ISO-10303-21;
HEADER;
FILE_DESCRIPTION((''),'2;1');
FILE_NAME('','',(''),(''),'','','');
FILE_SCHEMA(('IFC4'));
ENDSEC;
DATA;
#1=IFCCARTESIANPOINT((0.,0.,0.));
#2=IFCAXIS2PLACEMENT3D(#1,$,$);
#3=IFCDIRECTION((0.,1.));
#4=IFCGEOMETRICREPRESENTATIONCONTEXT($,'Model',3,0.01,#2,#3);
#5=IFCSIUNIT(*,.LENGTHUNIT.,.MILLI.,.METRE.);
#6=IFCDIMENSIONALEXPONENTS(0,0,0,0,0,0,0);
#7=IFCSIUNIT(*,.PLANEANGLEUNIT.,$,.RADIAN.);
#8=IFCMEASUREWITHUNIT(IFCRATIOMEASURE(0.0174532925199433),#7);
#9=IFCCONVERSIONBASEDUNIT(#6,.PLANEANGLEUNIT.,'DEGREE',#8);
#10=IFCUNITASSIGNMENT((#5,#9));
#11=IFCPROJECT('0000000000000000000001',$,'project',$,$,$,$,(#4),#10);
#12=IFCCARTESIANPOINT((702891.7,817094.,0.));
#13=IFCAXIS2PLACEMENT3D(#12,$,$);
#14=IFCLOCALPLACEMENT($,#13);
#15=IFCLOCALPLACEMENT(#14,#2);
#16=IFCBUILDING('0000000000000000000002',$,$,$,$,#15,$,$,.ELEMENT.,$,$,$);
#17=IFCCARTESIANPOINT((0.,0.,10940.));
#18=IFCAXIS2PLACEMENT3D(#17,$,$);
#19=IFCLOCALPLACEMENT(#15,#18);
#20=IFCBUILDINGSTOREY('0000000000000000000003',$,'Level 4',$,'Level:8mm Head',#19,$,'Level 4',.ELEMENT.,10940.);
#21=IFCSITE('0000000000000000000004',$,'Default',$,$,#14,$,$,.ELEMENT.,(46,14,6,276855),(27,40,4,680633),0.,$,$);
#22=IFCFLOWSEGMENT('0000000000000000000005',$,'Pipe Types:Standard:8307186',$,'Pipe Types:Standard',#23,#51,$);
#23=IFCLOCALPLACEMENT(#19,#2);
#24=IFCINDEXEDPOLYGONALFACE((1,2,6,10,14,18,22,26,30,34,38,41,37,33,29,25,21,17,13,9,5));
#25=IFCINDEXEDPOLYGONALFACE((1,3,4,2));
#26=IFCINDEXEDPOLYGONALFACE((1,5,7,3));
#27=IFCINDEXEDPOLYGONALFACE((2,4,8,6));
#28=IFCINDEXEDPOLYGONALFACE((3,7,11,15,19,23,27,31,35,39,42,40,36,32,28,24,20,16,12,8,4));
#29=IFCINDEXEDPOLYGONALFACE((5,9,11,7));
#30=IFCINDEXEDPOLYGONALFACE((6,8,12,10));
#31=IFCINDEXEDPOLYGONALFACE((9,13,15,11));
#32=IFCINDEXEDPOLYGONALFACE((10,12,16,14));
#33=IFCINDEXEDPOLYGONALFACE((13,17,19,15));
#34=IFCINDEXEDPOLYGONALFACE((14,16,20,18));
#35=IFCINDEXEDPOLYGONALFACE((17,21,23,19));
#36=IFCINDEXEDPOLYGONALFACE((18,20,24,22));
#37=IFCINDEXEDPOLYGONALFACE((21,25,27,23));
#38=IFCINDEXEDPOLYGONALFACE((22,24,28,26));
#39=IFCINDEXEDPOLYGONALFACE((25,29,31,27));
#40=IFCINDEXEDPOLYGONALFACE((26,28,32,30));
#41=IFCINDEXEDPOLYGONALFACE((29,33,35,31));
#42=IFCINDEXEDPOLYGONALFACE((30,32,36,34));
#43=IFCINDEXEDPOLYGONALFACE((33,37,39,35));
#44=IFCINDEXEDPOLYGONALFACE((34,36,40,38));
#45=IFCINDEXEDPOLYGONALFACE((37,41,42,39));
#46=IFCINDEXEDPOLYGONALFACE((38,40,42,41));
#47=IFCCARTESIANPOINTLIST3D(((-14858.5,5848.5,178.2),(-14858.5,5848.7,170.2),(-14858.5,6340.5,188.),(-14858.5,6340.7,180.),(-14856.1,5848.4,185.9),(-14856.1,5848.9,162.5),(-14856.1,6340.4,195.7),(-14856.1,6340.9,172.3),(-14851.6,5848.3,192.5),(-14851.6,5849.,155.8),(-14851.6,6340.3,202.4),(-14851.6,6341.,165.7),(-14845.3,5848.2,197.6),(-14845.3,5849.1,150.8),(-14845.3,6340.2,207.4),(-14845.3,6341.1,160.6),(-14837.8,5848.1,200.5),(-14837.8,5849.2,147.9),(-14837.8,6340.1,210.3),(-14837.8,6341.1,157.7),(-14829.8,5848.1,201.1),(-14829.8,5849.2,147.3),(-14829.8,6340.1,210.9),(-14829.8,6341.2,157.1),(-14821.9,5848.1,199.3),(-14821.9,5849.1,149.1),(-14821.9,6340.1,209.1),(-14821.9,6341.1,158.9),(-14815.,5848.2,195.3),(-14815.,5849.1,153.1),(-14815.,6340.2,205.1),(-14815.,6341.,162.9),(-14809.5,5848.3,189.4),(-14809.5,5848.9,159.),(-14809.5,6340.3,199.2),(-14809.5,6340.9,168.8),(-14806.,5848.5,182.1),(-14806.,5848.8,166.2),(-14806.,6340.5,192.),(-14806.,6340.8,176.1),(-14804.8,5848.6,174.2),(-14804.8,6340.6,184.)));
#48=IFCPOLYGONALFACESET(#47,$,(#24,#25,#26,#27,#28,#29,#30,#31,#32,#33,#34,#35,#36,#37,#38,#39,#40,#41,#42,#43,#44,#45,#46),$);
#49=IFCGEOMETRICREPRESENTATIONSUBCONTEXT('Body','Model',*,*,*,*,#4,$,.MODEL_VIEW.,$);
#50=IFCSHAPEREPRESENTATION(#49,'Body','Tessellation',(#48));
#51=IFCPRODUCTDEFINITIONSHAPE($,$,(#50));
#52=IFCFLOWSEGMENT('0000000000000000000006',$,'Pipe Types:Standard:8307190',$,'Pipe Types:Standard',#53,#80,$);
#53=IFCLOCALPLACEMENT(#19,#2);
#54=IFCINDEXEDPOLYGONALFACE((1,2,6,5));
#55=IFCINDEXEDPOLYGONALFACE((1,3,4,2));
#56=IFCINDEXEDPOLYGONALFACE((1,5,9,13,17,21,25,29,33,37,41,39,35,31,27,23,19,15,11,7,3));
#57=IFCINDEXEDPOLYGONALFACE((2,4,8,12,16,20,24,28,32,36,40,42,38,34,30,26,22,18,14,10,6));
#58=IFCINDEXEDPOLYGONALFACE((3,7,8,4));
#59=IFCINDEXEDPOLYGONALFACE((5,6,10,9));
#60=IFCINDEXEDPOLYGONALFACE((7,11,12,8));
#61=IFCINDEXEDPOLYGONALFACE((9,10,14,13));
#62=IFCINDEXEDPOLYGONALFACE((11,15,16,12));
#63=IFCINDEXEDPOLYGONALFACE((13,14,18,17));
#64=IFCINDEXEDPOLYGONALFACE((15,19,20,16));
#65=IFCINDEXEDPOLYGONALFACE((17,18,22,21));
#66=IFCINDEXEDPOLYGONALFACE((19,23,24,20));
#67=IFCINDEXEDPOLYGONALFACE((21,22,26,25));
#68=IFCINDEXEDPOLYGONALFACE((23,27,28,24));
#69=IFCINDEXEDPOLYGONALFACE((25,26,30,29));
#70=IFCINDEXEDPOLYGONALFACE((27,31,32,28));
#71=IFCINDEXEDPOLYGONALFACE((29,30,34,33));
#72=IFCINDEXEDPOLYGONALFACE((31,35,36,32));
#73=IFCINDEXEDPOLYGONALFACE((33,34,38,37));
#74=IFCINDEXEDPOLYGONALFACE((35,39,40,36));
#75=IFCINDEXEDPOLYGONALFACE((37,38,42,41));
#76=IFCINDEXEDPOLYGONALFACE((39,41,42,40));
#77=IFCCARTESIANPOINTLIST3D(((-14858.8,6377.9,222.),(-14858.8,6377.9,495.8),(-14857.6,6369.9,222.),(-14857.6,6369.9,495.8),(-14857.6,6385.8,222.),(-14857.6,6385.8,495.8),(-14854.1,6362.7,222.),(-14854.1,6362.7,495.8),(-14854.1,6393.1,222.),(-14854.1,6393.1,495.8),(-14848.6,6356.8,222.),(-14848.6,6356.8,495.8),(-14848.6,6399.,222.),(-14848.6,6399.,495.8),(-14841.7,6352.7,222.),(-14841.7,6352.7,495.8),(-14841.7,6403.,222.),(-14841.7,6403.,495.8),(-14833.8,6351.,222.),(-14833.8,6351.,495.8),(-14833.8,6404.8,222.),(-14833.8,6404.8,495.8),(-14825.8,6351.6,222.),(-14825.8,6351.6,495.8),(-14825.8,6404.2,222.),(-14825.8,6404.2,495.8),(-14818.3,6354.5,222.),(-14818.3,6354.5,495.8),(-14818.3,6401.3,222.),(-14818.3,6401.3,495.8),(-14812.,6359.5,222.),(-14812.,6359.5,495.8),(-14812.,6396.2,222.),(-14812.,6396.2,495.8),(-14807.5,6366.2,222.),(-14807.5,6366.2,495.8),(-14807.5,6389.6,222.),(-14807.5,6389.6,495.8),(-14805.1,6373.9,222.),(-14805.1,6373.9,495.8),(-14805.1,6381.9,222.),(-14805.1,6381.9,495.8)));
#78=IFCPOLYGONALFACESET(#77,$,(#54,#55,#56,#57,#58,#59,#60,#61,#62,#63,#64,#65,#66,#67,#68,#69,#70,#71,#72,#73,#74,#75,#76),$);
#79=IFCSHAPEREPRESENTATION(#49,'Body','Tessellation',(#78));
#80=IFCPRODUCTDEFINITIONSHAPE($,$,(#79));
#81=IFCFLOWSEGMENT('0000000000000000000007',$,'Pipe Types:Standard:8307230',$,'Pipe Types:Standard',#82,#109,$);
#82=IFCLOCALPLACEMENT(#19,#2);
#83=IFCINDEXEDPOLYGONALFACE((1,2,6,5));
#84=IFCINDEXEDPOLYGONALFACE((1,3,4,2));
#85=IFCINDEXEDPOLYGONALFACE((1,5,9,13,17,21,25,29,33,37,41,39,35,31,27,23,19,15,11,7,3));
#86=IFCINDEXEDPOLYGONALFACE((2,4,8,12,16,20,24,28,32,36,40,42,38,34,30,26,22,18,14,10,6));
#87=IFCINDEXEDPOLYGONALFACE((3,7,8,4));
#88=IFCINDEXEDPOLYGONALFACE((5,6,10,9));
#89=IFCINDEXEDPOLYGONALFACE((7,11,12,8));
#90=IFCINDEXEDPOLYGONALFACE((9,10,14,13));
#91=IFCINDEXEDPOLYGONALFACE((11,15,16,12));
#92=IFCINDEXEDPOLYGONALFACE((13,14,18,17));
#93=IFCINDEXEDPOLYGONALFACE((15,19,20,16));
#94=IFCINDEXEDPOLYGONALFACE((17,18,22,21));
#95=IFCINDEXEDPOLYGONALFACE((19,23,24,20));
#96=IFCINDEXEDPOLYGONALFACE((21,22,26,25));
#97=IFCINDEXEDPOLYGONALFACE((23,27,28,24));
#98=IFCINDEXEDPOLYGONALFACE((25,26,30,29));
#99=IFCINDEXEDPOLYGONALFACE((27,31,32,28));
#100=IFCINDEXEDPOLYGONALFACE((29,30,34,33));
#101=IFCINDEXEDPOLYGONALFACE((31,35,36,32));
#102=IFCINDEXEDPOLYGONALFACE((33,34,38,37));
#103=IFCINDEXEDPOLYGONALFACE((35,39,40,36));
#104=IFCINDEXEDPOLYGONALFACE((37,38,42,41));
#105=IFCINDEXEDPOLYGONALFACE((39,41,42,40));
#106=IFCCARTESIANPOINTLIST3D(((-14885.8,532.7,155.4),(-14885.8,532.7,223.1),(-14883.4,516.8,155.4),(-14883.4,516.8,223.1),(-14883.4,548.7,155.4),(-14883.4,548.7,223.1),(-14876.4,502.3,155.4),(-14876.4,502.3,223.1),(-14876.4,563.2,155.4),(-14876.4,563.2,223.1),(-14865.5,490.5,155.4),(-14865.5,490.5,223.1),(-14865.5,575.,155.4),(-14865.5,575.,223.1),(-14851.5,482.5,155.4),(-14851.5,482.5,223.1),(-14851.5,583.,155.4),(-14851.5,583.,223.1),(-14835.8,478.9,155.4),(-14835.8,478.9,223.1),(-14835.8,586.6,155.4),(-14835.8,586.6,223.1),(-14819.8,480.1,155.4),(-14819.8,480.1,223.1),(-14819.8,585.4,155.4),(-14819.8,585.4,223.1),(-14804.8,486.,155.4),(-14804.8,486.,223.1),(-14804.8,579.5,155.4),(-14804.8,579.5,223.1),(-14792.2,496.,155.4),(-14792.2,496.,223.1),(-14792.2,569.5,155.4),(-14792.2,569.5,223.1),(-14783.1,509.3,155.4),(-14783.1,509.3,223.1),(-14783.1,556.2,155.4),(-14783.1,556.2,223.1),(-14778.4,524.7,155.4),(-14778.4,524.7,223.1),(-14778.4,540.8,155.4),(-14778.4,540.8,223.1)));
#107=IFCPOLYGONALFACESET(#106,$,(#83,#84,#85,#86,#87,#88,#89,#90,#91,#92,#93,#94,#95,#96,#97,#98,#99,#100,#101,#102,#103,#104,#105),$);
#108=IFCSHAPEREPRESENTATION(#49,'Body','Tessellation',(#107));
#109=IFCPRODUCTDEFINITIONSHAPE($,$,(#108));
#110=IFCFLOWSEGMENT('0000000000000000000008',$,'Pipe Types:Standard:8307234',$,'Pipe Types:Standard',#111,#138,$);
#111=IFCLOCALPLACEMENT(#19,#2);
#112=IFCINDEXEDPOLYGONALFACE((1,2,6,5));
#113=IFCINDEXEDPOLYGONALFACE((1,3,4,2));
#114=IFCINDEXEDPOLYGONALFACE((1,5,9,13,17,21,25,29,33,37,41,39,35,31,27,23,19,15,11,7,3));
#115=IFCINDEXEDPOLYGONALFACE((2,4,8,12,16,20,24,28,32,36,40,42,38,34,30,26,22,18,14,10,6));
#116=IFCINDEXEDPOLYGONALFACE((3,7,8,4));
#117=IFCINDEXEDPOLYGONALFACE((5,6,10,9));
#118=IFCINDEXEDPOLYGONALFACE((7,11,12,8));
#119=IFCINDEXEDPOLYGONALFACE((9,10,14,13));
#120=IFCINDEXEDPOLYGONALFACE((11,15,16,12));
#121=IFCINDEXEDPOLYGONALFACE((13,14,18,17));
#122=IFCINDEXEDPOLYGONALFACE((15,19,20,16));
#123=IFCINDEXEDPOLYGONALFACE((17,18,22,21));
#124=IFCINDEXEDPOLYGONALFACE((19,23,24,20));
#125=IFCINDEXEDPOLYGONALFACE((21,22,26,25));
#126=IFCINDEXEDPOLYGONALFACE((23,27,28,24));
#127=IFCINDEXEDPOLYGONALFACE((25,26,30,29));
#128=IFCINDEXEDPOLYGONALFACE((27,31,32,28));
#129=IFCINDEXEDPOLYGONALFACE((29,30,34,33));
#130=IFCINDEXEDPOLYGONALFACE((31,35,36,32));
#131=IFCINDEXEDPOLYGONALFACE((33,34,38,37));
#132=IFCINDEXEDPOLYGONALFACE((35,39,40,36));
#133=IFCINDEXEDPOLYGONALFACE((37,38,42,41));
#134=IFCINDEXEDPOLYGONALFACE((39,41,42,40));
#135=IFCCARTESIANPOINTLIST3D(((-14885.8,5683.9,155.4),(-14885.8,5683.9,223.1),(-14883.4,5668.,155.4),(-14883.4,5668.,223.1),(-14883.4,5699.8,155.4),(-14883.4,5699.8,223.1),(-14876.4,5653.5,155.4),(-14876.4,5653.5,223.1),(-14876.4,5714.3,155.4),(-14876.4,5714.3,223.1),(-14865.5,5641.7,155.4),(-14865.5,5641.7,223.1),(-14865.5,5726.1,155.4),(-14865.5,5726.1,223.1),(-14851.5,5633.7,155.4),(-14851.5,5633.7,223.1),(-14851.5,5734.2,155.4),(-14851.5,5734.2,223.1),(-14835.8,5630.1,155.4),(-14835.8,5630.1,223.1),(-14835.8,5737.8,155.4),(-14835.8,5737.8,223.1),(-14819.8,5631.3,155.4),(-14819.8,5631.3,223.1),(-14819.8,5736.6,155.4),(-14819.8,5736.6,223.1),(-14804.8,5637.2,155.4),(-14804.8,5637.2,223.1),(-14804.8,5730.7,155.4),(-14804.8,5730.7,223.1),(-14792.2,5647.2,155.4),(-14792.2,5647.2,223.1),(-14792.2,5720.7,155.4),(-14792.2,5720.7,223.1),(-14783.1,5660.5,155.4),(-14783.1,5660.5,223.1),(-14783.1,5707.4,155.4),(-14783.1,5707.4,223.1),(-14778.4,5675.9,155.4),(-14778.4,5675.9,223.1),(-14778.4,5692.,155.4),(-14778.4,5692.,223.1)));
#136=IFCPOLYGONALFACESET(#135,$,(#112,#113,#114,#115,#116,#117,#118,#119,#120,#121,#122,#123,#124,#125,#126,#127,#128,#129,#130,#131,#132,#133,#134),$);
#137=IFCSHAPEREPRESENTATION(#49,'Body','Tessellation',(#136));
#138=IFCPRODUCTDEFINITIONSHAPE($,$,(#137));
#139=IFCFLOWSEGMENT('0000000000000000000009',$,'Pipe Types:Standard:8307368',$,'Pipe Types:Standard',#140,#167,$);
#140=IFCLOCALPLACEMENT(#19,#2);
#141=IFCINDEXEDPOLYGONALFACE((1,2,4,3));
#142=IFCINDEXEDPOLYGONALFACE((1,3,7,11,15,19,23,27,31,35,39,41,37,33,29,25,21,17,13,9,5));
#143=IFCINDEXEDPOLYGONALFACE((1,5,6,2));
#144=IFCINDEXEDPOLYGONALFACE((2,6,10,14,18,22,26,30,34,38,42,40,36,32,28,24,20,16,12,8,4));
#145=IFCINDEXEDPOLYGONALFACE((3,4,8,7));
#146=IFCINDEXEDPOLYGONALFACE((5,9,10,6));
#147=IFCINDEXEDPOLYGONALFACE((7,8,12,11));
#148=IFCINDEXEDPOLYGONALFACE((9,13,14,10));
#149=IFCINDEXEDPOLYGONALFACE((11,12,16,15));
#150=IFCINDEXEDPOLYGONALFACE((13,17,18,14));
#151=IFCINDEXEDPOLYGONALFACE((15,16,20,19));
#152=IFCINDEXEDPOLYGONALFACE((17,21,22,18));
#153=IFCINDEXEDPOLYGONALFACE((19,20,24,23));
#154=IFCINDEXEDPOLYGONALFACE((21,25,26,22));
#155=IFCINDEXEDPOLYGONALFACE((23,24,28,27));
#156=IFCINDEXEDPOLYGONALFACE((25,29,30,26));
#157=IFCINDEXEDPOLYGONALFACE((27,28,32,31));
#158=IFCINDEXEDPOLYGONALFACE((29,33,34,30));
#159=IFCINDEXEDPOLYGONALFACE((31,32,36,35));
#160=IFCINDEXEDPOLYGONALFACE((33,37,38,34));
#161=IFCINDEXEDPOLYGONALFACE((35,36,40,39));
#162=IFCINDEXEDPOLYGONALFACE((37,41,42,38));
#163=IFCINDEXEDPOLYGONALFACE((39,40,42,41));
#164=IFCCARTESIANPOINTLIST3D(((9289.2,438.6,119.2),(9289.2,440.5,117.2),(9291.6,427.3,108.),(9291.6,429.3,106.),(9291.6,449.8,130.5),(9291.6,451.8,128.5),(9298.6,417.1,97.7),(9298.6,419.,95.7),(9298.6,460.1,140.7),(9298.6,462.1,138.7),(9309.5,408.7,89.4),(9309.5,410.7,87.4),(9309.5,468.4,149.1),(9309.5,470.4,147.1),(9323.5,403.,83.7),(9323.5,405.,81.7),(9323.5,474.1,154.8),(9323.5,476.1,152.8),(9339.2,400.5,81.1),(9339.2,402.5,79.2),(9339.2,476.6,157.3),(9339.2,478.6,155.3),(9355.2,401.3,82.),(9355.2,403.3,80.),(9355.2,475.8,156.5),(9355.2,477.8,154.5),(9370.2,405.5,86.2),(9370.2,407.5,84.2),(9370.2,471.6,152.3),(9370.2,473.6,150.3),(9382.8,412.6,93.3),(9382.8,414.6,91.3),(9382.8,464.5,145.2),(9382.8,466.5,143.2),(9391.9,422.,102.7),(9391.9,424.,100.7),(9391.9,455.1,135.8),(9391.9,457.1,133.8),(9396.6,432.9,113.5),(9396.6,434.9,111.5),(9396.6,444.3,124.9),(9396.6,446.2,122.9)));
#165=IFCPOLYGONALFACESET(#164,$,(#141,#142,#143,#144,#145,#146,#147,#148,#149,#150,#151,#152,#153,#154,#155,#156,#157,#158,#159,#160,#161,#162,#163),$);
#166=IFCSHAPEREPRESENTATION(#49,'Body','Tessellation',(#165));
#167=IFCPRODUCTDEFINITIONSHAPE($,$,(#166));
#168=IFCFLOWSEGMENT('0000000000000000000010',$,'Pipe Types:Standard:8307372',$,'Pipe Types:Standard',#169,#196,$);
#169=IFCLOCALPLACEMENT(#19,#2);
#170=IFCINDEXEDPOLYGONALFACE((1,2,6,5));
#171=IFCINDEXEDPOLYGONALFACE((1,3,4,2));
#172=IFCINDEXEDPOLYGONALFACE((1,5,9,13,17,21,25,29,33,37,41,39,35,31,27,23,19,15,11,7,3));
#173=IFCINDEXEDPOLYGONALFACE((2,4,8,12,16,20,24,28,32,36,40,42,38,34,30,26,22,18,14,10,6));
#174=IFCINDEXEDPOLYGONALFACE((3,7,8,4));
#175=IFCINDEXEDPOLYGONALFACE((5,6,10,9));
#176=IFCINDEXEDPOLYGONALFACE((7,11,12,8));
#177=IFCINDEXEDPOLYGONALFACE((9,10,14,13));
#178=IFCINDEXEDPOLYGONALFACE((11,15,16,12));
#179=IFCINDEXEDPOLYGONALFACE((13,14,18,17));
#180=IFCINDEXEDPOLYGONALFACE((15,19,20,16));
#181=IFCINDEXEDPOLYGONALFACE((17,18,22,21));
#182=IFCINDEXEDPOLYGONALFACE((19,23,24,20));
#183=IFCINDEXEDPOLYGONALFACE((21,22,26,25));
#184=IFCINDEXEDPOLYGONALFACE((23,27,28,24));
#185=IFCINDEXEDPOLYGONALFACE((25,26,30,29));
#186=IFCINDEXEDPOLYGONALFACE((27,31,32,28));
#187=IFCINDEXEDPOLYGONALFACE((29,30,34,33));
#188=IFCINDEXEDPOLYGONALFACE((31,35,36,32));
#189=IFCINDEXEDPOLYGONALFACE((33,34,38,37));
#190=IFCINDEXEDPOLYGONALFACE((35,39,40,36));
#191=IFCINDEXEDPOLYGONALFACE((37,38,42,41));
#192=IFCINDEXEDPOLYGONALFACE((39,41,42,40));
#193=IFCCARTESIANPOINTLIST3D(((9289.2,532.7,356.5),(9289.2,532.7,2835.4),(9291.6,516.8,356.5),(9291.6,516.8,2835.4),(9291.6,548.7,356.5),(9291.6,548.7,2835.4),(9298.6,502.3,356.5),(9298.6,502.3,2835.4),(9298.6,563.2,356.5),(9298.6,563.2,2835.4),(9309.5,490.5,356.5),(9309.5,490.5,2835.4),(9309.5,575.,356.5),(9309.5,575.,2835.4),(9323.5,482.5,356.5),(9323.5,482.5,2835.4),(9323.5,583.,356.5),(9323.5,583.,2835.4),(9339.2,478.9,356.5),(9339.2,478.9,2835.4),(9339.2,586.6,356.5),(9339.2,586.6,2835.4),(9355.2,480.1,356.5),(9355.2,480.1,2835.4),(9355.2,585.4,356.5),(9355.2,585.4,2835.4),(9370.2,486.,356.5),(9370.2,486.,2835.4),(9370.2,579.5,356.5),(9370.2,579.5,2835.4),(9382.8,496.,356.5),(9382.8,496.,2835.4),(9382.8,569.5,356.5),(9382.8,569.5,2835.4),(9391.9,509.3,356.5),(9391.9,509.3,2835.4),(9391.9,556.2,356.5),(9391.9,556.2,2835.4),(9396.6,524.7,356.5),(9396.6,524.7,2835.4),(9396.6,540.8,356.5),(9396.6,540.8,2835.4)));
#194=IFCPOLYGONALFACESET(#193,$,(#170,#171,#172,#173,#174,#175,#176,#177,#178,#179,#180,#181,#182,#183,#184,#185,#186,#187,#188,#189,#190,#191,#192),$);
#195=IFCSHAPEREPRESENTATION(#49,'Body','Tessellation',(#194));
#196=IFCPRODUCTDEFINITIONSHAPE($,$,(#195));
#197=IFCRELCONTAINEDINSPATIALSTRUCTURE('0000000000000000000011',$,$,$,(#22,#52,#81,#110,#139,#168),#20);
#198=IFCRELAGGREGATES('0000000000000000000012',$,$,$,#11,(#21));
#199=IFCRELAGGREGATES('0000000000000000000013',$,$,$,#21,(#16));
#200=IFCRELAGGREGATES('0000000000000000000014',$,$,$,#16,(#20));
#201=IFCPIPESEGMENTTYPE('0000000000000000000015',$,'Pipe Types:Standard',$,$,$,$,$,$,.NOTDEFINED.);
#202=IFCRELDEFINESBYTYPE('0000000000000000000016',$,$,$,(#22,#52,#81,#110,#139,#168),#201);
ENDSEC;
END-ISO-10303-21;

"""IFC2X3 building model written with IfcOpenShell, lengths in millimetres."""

from ifc_helpers import new_model, entity, si_unit, converted_unit, direction, frame, frame_2d, origin, origin_2d_with_axis, place, context, subcontext, project, spatial, circle, extrude, type_object, element, save


model = new_model("IFC2X3")

# Units and contexts
model_context = context("Model", 3, precision=0.01, world=origin(), true_north=direction((0.0, 1.0)))
body_context = subcontext(model_context, "Body", "Model", "MODEL_VIEW")
ifc_project = project(units=[si_unit("LENGTHUNIT", "METRE", prefix="MILLI"), converted_unit("PLANEANGLEUNIT", "DEGREE", entity("IfcRatioMeasure", 0.0174532925199433), si_unit("PLANEANGLEUNIT", "RADIAN"), dimensions=[0, 0, 0, 0, 0, 0, 0])], contexts=[model_context])

# Site, building, storey
site_placement = place(None, frame((702891.7, 817094.0, 0.0)))
site = spatial("IfcSite", under=ifc_project, at=site_placement, Name="Default", CompositionType="ELEMENT", RefLatitude=(46, 14, 6, 276855), RefLongitude=(27, 40, 4, 680633), RefElevation=0.0)
building_placement = place(site_placement, origin())
building = spatial("IfcBuilding", under=site, at=building_placement, CompositionType="ELEMENT")
storey_placement = place(building_placement, frame((0.0, 0.0, 10940.0)))
storey = spatial("IfcBuildingStorey", under=building, at=storey_placement, Name="Level 4", ObjectType="Level:8mm Head", LongName="Level 4", CompositionType="ELEMENT", Elevation=10940.0)

# Flow segments
pipe_segment_type = type_object("IfcPipeSegmentType", Name="Pipe Types:Standard", PredefinedType="NOTDEFINED")
flow_segment_1_placement = place(storey_placement, origin())
element("IfcFlowSegment", 1, at=flow_segment_1_placement, inside=storey, type_object=pipe_segment_type, Name="Pipe Types:Standard:8307186", ObjectType="Pipe Types:Standard", context=body_context, shape_type="SweptSolid", body=[
    extrude(circle(Radius=27.0, at=origin_2d_with_axis()), frame((-14831.8, 5848.6, 174.2), z_axis=(0.0, 0.9998, 0.019996), x_axis=(1.0, 0.0, 0.0)), (0.0, 0.0, 1.0), 492.1),
])
flow_segment_2_placement = place(storey_placement, origin())
element("IfcFlowSegment", 2, at=flow_segment_2_placement, inside=storey, type_object=pipe_segment_type, Name="Pipe Types:Standard:8307190", ObjectType="Pipe Types:Standard", context=body_context, shape_type="SweptSolid", body=[
    extrude(circle(Radius=27.0, at=origin_2d_with_axis()), frame((-14831.8, 6377.9, 222.0), z_axis=(0.0, -0.000001, 1.0), x_axis=(-1.0, 0.0, 0.0)), (0.0, 0.0, 1.0), 273.7),
])
flow_segment_3_placement = place(storey_placement, origin())
element("IfcFlowSegment", 3, at=flow_segment_3_placement, inside=storey, type_object=pipe_segment_type, Name="Pipe Types:Standard:8307230", ObjectType="Pipe Types:Standard", context=body_context, shape_type="SweptSolid", body=[
    extrude(circle(Radius=54.0, at=frame_2d((0.0, 0.0), x_axis=(1.0, 0.0))), frame((-14831.8, 532.7, 155.4), z_axis=(0.0, 0.0, 1.0), x_axis=(-1.0, 0.0, 0.0)), (0.0, 0.0, 1.0), 67.6),
])
flow_segment_4_placement = place(storey_placement, origin())
element("IfcFlowSegment", 4, at=flow_segment_4_placement, inside=storey, type_object=pipe_segment_type, Name="Pipe Types:Standard:8307234", ObjectType="Pipe Types:Standard", context=body_context, shape_type="SweptSolid", body=[
    extrude(circle(Radius=54.0, at=origin_2d_with_axis()), frame((-14831.8, 5683.9, 155.4), z_axis=(0.0, 0.0, 1.0), x_axis=(-1.0, 0.0, 0.0)), (0.0, 0.0, 1.0), 67.6),
])
flow_segment_5_placement = place(storey_placement, origin())
element("IfcFlowSegment", 5, at=flow_segment_5_placement, inside=storey, type_object=pipe_segment_type, Name="Pipe Types:Standard:8307368", ObjectType="Pipe Types:Standard", context=body_context, shape_type="SweptSolid", body=[
    extrude(circle(Radius=54.0, at=frame_2d((0.0, 0.0), x_axis=(1.0, 0.0))), frame((9343.2, 438.6, 119.2), z_axis=(0.0, 0.707107, -0.707107), x_axis=(-1.0, 0.0, 0.0)), (0.0, 0.0, 1.0), 2.8),
])
flow_segment_6_placement = place(storey_placement, origin())
element("IfcFlowSegment", 6, at=flow_segment_6_placement, inside=storey, type_object=pipe_segment_type, Name="Pipe Types:Standard:8307372", ObjectType="Pipe Types:Standard", context=body_context, shape_type="SweptSolid", body=[
    extrude(circle(Radius=54.0, at=frame_2d((0.0, 0.0), x_axis=(1.0, 0.0))), frame((9343.2, 532.7, 356.5), z_axis=(0.0, 0.0, 1.0), x_axis=(-1.0, 0.0, 0.0)), (0.0, 0.0, 1.0), 2479.0),
])

save(model, "model.ifc")
